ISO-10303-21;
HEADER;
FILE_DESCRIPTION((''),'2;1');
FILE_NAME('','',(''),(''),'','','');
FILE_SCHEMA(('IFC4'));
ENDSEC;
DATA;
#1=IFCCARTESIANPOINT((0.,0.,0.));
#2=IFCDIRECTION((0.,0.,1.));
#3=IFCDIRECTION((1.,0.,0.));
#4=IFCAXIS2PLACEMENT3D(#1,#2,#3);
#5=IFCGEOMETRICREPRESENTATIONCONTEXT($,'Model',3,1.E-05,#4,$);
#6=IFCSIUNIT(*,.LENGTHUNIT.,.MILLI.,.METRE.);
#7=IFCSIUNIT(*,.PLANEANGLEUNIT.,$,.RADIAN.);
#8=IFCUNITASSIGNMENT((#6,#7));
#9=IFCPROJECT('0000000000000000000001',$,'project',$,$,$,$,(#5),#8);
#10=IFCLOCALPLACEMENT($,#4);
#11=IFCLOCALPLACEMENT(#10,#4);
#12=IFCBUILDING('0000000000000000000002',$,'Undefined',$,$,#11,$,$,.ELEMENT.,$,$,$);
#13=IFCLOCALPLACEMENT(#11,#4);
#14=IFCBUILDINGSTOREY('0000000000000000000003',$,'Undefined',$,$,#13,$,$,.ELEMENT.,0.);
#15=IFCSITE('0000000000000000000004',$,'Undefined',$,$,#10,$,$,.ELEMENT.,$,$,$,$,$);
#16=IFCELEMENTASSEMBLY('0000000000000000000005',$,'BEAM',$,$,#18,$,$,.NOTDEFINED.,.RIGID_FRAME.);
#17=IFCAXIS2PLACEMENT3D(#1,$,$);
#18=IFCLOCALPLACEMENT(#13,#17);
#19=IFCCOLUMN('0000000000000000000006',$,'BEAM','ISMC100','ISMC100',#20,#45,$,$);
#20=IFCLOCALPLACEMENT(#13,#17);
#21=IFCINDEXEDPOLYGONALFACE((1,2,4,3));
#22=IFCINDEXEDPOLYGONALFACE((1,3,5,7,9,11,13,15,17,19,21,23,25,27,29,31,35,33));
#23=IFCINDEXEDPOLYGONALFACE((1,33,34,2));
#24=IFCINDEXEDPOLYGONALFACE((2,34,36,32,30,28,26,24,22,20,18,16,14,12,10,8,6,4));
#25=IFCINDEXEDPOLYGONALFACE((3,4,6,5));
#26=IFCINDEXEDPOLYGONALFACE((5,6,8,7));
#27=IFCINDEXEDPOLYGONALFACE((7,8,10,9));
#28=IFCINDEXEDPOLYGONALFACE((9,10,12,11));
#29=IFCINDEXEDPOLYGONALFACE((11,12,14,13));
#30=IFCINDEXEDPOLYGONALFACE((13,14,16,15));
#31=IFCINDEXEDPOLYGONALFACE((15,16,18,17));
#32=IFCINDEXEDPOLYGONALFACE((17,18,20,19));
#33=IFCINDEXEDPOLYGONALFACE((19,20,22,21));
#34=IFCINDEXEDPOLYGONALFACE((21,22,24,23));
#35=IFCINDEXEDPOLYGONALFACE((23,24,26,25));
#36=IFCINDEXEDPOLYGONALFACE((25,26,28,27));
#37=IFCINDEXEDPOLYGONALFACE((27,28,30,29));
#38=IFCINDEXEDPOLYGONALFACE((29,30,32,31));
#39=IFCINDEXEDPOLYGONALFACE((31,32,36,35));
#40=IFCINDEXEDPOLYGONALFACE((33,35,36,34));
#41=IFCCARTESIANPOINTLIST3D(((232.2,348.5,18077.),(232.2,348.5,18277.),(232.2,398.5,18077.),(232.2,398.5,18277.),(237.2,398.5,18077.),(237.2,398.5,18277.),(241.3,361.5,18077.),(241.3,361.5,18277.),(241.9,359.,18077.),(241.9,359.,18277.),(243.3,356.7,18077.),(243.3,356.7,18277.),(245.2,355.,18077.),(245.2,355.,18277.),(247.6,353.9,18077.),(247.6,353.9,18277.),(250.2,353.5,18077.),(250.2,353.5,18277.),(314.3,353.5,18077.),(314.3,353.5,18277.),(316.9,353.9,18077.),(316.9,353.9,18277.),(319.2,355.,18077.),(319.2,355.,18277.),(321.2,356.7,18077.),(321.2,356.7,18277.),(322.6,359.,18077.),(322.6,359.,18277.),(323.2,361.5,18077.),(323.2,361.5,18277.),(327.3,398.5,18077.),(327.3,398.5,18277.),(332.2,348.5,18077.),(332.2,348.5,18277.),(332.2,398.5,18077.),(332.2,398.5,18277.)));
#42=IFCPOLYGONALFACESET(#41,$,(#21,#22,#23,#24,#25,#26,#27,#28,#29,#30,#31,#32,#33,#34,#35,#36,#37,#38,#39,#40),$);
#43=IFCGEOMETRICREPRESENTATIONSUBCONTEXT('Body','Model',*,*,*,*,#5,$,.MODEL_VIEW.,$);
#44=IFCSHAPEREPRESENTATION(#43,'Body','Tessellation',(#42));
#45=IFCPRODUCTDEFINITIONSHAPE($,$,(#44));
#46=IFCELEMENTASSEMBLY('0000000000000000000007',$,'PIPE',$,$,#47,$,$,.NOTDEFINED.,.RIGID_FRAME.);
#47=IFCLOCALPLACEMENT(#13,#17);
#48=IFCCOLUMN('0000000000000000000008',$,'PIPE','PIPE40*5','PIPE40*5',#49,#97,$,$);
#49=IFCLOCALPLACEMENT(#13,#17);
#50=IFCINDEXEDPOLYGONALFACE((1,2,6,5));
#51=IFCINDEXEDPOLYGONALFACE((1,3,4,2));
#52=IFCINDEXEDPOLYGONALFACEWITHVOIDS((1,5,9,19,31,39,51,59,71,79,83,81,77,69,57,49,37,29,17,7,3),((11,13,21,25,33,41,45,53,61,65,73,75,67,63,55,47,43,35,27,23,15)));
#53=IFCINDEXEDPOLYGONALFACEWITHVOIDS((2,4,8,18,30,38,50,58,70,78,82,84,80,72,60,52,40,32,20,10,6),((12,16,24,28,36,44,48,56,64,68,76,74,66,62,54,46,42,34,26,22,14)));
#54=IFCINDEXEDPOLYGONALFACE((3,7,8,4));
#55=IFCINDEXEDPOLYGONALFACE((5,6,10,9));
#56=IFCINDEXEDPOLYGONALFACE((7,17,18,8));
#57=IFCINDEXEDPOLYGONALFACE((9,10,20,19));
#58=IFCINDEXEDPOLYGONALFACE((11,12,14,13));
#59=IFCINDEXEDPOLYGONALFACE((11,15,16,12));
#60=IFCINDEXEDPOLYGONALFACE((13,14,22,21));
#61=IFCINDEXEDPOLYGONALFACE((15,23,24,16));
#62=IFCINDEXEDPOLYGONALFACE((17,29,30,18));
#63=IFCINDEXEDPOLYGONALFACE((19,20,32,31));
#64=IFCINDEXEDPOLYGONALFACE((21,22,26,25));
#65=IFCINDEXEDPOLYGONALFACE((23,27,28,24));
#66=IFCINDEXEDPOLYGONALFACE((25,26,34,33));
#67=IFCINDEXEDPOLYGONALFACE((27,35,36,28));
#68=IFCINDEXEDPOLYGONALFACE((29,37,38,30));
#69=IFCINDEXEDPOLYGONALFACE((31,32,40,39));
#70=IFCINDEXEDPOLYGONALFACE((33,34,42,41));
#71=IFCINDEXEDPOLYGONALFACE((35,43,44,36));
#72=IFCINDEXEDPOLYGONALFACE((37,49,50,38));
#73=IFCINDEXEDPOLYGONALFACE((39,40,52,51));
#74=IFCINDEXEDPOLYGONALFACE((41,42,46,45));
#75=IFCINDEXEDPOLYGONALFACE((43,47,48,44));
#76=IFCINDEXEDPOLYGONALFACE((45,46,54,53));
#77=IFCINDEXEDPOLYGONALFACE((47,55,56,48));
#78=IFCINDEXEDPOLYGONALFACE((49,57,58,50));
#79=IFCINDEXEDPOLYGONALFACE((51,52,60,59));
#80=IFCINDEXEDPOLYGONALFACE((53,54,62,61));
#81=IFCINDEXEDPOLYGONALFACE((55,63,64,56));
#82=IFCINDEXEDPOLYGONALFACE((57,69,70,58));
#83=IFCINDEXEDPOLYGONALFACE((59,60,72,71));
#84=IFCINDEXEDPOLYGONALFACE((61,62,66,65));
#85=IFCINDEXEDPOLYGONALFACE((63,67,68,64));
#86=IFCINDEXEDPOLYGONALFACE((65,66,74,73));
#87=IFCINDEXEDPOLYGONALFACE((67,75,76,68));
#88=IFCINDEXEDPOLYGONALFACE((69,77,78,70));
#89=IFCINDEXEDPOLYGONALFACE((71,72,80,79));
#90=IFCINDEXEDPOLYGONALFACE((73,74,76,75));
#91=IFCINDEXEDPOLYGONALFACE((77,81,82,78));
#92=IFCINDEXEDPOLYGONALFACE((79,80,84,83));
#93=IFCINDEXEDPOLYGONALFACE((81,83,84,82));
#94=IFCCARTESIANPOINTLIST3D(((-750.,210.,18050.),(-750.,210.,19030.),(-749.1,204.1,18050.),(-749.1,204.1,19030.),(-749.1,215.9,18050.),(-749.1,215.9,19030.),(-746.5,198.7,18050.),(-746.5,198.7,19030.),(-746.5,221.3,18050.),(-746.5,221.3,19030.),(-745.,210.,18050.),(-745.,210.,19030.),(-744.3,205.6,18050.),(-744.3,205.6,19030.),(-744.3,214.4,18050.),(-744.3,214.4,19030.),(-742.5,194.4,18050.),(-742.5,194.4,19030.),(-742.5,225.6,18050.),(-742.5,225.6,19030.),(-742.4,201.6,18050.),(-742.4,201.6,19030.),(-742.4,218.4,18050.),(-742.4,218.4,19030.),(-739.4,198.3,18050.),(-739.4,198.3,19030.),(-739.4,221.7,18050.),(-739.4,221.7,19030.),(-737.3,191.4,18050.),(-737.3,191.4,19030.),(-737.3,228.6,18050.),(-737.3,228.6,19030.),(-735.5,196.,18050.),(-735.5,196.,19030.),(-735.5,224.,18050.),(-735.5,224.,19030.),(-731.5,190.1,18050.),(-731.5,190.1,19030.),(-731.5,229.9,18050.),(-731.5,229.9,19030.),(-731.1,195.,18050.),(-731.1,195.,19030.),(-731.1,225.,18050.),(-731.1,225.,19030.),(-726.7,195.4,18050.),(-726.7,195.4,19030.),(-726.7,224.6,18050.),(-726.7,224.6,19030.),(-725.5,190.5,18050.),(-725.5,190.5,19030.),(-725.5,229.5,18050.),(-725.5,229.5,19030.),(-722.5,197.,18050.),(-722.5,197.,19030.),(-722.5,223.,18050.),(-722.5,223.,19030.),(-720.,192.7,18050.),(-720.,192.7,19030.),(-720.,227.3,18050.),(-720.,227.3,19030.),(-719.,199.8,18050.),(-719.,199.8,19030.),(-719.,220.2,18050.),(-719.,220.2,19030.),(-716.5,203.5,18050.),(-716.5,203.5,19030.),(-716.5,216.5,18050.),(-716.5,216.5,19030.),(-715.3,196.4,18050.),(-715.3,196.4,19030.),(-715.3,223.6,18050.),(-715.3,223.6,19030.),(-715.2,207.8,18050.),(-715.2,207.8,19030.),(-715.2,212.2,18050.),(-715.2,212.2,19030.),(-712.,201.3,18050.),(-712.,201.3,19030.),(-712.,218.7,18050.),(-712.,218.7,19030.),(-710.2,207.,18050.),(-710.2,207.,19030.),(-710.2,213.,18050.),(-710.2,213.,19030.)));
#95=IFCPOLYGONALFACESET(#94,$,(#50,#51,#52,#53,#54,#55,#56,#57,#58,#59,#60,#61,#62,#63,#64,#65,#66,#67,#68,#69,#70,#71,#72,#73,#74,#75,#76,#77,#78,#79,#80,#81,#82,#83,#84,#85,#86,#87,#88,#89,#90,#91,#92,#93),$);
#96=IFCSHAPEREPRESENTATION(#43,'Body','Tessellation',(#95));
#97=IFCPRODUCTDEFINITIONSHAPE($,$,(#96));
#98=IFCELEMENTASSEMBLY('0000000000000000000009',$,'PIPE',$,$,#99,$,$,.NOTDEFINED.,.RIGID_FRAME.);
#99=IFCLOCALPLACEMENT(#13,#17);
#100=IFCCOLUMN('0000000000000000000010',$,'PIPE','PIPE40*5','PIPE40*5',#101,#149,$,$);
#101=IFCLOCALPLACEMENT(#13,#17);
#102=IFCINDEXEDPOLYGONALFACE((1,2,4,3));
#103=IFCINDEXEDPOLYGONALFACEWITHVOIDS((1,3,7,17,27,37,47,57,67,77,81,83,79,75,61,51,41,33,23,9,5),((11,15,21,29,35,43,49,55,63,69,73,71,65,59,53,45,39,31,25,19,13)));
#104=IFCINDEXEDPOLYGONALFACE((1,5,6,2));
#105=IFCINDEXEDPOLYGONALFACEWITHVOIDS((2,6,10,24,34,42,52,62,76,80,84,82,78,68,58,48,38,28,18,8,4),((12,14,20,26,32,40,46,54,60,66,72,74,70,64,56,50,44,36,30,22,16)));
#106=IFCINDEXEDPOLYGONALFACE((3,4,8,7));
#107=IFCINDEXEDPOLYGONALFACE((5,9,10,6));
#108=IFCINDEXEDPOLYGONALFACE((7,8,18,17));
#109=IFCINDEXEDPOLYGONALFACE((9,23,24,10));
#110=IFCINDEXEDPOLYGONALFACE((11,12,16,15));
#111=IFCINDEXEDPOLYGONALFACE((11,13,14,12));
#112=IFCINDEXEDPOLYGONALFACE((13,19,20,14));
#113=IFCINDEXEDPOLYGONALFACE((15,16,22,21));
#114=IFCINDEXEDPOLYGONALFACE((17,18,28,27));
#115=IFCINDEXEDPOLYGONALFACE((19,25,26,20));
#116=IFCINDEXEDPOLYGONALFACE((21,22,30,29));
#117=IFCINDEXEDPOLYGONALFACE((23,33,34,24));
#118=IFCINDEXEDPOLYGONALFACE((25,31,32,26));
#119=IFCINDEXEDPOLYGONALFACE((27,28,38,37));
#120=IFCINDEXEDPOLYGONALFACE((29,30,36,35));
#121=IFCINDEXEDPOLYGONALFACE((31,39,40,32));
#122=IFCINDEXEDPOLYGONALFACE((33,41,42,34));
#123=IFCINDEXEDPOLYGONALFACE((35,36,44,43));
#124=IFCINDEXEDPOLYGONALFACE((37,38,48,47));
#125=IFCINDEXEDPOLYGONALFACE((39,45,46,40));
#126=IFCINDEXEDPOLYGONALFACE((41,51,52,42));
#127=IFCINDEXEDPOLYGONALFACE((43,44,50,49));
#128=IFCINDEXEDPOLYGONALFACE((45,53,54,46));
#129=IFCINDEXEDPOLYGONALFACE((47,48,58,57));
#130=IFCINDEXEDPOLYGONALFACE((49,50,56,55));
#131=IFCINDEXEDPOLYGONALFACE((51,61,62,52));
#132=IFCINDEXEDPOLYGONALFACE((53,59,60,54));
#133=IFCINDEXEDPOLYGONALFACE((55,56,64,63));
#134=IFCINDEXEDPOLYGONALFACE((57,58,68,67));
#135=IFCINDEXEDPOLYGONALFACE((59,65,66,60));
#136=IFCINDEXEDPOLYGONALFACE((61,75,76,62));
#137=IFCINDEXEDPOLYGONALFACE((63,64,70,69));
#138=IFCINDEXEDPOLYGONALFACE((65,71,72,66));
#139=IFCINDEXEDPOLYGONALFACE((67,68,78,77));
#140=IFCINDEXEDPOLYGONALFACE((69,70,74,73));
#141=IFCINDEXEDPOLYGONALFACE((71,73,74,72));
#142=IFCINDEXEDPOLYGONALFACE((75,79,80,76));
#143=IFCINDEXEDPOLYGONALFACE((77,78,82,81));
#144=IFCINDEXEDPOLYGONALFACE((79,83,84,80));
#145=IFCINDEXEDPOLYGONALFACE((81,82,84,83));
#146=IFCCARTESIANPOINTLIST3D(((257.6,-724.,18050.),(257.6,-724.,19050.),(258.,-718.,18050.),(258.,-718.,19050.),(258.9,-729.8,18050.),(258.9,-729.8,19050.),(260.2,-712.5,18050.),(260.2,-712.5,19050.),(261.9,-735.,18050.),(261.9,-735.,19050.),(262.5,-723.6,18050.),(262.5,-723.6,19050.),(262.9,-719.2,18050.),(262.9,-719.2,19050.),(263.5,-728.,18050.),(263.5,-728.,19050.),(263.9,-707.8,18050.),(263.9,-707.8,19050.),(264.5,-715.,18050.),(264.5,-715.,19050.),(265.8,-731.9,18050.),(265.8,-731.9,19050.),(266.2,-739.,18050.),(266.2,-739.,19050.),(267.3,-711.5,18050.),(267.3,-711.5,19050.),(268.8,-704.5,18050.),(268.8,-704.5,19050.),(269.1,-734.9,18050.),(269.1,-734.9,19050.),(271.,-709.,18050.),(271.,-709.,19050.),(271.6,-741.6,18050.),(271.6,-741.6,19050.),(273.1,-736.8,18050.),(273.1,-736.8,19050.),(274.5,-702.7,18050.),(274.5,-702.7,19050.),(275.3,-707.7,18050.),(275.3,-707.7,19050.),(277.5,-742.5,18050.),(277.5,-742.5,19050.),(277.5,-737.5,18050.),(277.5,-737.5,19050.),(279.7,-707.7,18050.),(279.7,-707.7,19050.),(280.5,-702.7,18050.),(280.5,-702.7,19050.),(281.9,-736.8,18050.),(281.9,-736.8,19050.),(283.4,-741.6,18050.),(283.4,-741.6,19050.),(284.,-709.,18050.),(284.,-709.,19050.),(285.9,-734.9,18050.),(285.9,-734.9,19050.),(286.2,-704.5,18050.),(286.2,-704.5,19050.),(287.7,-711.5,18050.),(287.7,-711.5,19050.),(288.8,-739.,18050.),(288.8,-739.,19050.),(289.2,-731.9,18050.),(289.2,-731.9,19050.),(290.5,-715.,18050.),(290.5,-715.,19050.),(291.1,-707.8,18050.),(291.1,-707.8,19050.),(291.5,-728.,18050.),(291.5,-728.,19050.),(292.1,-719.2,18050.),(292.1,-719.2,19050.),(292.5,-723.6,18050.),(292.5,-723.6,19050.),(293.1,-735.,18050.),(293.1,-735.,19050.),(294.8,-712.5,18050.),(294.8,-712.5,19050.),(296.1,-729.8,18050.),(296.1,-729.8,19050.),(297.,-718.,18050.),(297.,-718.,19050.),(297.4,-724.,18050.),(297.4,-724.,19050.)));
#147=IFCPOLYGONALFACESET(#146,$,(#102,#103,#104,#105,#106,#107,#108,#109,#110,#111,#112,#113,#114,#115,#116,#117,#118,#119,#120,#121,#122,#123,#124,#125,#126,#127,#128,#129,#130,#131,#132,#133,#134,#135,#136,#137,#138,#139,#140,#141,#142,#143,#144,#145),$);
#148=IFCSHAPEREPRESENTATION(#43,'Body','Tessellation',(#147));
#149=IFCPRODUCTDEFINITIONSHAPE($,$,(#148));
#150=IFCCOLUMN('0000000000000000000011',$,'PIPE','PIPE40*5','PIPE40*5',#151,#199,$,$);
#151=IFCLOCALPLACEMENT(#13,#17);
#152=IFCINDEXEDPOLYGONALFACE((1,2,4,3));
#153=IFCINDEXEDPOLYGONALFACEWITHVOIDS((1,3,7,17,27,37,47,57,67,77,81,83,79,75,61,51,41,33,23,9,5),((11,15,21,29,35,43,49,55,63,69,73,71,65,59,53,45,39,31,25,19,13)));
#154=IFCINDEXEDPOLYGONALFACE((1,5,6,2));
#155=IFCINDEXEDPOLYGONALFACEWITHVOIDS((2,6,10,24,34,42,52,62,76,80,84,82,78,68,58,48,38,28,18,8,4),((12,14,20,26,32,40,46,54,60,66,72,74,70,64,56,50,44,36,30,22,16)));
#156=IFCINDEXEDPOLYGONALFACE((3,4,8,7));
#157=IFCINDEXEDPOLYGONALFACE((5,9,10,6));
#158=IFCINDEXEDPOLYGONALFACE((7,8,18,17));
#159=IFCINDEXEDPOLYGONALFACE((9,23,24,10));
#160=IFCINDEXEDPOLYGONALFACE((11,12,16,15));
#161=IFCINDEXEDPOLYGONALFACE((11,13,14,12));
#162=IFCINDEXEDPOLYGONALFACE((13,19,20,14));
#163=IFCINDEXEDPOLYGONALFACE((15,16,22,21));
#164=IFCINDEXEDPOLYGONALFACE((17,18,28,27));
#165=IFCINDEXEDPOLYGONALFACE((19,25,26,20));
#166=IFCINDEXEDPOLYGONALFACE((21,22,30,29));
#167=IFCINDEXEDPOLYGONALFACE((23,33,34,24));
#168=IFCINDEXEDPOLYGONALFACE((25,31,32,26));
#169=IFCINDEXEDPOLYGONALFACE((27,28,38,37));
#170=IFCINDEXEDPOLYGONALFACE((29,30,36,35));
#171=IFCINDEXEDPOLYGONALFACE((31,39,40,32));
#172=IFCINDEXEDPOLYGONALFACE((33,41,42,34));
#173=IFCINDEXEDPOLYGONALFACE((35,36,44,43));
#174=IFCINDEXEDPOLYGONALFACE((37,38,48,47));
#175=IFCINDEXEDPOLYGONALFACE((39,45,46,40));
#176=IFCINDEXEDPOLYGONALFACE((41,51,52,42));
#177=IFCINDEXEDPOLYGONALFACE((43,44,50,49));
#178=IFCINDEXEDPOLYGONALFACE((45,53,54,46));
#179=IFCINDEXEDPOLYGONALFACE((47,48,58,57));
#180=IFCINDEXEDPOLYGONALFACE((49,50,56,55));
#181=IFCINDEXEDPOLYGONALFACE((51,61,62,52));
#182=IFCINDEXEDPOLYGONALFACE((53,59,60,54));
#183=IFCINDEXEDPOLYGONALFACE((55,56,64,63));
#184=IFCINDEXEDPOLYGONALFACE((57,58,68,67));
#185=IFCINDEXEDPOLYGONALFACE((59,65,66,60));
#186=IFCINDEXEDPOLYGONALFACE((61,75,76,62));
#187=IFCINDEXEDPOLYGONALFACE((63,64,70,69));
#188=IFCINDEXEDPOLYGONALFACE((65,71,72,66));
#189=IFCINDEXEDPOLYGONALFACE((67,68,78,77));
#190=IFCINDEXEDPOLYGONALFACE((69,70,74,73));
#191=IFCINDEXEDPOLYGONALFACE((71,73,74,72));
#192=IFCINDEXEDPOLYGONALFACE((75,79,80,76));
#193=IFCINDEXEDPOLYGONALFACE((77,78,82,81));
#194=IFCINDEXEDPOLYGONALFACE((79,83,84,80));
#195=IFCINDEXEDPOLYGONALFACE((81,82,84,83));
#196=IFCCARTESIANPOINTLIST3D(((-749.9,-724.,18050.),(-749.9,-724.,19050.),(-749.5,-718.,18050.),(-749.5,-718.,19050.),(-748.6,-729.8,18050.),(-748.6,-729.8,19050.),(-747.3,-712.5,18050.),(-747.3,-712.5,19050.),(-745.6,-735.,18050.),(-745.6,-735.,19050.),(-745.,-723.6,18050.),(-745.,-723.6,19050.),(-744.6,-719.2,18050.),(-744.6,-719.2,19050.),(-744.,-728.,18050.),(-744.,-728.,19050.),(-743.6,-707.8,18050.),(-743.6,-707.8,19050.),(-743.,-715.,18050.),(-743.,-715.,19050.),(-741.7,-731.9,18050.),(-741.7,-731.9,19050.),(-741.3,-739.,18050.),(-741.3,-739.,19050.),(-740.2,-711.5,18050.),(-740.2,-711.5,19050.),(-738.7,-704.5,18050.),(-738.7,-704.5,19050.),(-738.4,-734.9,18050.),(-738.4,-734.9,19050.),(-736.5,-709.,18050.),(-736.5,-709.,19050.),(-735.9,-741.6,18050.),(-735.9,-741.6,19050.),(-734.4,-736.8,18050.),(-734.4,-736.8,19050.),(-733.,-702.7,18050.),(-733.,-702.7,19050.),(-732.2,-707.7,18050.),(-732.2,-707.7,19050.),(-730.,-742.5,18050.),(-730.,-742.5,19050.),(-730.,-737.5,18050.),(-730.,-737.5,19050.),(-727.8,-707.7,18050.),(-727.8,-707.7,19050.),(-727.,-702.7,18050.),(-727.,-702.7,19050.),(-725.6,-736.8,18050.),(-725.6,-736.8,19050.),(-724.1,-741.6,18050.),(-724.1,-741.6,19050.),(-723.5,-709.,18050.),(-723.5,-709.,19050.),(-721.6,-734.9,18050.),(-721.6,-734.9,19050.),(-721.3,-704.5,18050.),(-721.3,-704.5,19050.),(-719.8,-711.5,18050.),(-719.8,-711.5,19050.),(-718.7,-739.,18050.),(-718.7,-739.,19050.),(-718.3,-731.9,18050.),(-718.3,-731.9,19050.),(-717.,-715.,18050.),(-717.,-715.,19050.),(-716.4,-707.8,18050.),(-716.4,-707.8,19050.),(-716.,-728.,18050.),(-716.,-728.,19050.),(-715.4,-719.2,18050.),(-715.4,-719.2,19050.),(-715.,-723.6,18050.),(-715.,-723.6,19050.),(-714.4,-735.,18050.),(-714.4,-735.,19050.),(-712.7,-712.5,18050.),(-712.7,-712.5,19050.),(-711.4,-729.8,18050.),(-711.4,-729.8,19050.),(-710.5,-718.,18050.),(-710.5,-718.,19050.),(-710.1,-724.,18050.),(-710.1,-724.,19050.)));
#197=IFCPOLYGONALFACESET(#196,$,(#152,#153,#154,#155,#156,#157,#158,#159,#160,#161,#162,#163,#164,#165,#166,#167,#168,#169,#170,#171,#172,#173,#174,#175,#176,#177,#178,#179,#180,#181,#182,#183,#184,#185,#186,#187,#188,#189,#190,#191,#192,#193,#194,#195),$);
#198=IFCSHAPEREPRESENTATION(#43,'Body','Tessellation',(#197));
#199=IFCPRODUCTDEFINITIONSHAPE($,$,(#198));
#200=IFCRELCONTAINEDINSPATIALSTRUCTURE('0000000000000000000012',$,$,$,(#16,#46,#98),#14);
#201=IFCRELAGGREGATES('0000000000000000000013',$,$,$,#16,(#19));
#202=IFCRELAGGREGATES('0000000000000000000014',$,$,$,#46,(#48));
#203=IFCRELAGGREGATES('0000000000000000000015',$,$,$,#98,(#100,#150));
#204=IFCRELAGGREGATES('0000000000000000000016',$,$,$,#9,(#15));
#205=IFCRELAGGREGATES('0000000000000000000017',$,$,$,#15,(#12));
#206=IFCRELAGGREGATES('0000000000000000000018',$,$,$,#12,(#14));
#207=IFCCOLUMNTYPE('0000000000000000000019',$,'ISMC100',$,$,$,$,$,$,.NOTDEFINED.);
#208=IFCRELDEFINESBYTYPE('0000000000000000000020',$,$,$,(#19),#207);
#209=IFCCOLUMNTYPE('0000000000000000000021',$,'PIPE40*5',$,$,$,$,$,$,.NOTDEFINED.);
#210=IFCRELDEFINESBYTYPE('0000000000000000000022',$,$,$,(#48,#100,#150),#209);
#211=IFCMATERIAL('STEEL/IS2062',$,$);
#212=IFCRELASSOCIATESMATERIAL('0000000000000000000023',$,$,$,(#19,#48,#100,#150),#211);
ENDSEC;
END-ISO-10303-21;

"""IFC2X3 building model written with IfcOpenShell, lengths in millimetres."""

from ifc_helpers import new_model, si_unit, frame, origin_with_axes, origin_2d_with_axis, place, context, subcontext, project, spatial, hollow_circle, u_section, extrude, clip, halfspace, material, type_object, element, aggregate, save


model = new_model("IFC2X3")

# Units and contexts
model_context = context("Model", 3, precision=1e-05, world=origin_with_axes())
body_context = subcontext(model_context, "Body", "Model", "MODEL_VIEW")
ifc_project = project(units=[si_unit("LENGTHUNIT", "METRE", prefix="MILLI"), si_unit("PLANEANGLEUNIT", "RADIAN")], contexts=[model_context])

# Site, building, storey
site_placement = place(None, origin_with_axes())
site = spatial("IfcSite", under=ifc_project, at=site_placement, Name="Undefined", CompositionType="ELEMENT")
building_placement = place(site_placement, origin_with_axes())
building = spatial("IfcBuilding", under=site, at=building_placement, Name="Undefined", CompositionType="ELEMENT")
storey_placement = place(building_placement, origin_with_axes())
storey = spatial("IfcBuildingStorey", under=building, at=storey_placement, Name="Undefined", CompositionType="ELEMENT", Elevation=0.0)

# Element assemblies, columns
assembly_1_placement = place(storey_placement, origin_with_axes())
assembly_1 = element("IfcElementAssembly", 1, at=assembly_1_placement, inside=storey, Name="BEAM", AssemblyPlace="NOTDEFINED", PredefinedType="RIGID_FRAME")
ifc_material_1 = material(Name="STEEL/IS2062")
column_type_1 = type_object("IfcColumnType", Name="ISMC100", PredefinedType="NOTDEFINED")
column_1_placement = place(assembly_1_placement, frame((282.2, 373.5, 18077.0), z_axis=(0.0, 0.0, 1.0), x_axis=(1.0, 0.0, 0.0)))
column_1 = element("IfcColumn", 2, at=column_1_placement, type_object=column_type_1, material=ifc_material_1, Name="BEAM", Description="ISMC100", ObjectType="ISMC100", context=body_context, shape_type="SweptSolid", body=[
    extrude(u_section(Depth=100.0, FlangeWidth=50.0, WebThickness=5.0, FlangeThickness=7.7, FilletRadius=9.0, FlangeSlope=0.10956, at=origin_2d_with_axis()), frame((0.0, 0.0, 200.0), z_axis=(0.0, 0.0, -1.0), x_axis=(0.0, 1.0, 0.0)), (0.0, 0.0, 1.0), 200.0),
])
aggregate(assembly_1, [column_1])
assembly_2_placement = place(storey_placement, origin_with_axes())
assembly_2 = element("IfcElementAssembly", 3, at=assembly_2_placement, inside=storey, Name="PIPE", AssemblyPlace="NOTDEFINED", PredefinedType="RIGID_FRAME")
column_type_2 = type_object("IfcColumnType", Name="PIPE40*5", PredefinedType="NOTDEFINED")
column_2_placement = place(assembly_2_placement, frame((-730.0, 210.0, 18050.0), z_axis=(0.0, 0.0, 1.0), x_axis=(0.0, 1.0, 0.0)))
column_2 = element("IfcColumn", 4, at=column_2_placement, type_object=column_type_2, material=ifc_material_1, Name="PIPE", Description="PIPE40*5", ObjectType="PIPE40*5", context=body_context, shape_type="Clipping", body=[
    clip(extrude(hollow_circle(Radius=20.0, WallThickness=5.0, at=origin_2d_with_axis()), frame((0.0, 0.0, 1000.0), z_axis=(0.0, 0.0, -1.0), x_axis=(0.0, 1.0, 0.0)), (0.0, 0.0, 1.0), 1000.0), halfspace(frame((0.0, 0.0, 980.0), z_axis=(0.0, 0.0, 1.0), x_axis=(1.0, 0.0, 0.0)), False)),
])
aggregate(assembly_2, [column_2])

# Element assembly, columns
assembly_3_placement = place(storey_placement, origin_with_axes())
assembly_3 = element("IfcElementAssembly", 5, at=assembly_3_placement, inside=storey, Name="PIPE", AssemblyPlace="NOTDEFINED", PredefinedType="RIGID_FRAME")
column_3_placement = place(assembly_3_placement, frame((277.5, -722.5, 18050.0), z_axis=(0.0, 0.0, 1.0), x_axis=(-1.0, 0.0, 0.0)))
column_3 = element("IfcColumn", 6, at=column_3_placement, type_object=column_type_2, material=ifc_material_1, Name="PIPE", Description="PIPE40*5", ObjectType="PIPE40*5", context=body_context, shape_type="SweptSolid", body=[
    extrude(hollow_circle(Radius=20.0, WallThickness=5.0, at=origin_2d_with_axis()), frame((0.0, 0.0, 1000.0), z_axis=(0.0, 0.0, -1.0), x_axis=(0.0, 1.0, 0.0)), (0.0, 0.0, 1.0), 1000.0),
])
column_4_placement = place(assembly_3_placement, frame((-730.0, -722.5, 18050.0), z_axis=(0.0, 0.0, 1.0), x_axis=(-1.0, 0.0, 0.0)))
column_4 = element("IfcColumn", 7, at=column_4_placement, type_object=column_type_2, material=ifc_material_1, Name="PIPE", Description="PIPE40*5", ObjectType="PIPE40*5", context=body_context, shape_type="SweptSolid", body=[
    extrude(hollow_circle(Radius=20.0, WallThickness=5.0, at=origin_2d_with_axis()), frame((0.0, 0.0, 1000.0), z_axis=(0.0, 0.0, -1.0), x_axis=(0.0, 1.0, 0.0)), (0.0, 0.0, 1.0), 1000.0),
])
aggregate(assembly_3, [column_3, column_4])

save(model, "model.ifc")
